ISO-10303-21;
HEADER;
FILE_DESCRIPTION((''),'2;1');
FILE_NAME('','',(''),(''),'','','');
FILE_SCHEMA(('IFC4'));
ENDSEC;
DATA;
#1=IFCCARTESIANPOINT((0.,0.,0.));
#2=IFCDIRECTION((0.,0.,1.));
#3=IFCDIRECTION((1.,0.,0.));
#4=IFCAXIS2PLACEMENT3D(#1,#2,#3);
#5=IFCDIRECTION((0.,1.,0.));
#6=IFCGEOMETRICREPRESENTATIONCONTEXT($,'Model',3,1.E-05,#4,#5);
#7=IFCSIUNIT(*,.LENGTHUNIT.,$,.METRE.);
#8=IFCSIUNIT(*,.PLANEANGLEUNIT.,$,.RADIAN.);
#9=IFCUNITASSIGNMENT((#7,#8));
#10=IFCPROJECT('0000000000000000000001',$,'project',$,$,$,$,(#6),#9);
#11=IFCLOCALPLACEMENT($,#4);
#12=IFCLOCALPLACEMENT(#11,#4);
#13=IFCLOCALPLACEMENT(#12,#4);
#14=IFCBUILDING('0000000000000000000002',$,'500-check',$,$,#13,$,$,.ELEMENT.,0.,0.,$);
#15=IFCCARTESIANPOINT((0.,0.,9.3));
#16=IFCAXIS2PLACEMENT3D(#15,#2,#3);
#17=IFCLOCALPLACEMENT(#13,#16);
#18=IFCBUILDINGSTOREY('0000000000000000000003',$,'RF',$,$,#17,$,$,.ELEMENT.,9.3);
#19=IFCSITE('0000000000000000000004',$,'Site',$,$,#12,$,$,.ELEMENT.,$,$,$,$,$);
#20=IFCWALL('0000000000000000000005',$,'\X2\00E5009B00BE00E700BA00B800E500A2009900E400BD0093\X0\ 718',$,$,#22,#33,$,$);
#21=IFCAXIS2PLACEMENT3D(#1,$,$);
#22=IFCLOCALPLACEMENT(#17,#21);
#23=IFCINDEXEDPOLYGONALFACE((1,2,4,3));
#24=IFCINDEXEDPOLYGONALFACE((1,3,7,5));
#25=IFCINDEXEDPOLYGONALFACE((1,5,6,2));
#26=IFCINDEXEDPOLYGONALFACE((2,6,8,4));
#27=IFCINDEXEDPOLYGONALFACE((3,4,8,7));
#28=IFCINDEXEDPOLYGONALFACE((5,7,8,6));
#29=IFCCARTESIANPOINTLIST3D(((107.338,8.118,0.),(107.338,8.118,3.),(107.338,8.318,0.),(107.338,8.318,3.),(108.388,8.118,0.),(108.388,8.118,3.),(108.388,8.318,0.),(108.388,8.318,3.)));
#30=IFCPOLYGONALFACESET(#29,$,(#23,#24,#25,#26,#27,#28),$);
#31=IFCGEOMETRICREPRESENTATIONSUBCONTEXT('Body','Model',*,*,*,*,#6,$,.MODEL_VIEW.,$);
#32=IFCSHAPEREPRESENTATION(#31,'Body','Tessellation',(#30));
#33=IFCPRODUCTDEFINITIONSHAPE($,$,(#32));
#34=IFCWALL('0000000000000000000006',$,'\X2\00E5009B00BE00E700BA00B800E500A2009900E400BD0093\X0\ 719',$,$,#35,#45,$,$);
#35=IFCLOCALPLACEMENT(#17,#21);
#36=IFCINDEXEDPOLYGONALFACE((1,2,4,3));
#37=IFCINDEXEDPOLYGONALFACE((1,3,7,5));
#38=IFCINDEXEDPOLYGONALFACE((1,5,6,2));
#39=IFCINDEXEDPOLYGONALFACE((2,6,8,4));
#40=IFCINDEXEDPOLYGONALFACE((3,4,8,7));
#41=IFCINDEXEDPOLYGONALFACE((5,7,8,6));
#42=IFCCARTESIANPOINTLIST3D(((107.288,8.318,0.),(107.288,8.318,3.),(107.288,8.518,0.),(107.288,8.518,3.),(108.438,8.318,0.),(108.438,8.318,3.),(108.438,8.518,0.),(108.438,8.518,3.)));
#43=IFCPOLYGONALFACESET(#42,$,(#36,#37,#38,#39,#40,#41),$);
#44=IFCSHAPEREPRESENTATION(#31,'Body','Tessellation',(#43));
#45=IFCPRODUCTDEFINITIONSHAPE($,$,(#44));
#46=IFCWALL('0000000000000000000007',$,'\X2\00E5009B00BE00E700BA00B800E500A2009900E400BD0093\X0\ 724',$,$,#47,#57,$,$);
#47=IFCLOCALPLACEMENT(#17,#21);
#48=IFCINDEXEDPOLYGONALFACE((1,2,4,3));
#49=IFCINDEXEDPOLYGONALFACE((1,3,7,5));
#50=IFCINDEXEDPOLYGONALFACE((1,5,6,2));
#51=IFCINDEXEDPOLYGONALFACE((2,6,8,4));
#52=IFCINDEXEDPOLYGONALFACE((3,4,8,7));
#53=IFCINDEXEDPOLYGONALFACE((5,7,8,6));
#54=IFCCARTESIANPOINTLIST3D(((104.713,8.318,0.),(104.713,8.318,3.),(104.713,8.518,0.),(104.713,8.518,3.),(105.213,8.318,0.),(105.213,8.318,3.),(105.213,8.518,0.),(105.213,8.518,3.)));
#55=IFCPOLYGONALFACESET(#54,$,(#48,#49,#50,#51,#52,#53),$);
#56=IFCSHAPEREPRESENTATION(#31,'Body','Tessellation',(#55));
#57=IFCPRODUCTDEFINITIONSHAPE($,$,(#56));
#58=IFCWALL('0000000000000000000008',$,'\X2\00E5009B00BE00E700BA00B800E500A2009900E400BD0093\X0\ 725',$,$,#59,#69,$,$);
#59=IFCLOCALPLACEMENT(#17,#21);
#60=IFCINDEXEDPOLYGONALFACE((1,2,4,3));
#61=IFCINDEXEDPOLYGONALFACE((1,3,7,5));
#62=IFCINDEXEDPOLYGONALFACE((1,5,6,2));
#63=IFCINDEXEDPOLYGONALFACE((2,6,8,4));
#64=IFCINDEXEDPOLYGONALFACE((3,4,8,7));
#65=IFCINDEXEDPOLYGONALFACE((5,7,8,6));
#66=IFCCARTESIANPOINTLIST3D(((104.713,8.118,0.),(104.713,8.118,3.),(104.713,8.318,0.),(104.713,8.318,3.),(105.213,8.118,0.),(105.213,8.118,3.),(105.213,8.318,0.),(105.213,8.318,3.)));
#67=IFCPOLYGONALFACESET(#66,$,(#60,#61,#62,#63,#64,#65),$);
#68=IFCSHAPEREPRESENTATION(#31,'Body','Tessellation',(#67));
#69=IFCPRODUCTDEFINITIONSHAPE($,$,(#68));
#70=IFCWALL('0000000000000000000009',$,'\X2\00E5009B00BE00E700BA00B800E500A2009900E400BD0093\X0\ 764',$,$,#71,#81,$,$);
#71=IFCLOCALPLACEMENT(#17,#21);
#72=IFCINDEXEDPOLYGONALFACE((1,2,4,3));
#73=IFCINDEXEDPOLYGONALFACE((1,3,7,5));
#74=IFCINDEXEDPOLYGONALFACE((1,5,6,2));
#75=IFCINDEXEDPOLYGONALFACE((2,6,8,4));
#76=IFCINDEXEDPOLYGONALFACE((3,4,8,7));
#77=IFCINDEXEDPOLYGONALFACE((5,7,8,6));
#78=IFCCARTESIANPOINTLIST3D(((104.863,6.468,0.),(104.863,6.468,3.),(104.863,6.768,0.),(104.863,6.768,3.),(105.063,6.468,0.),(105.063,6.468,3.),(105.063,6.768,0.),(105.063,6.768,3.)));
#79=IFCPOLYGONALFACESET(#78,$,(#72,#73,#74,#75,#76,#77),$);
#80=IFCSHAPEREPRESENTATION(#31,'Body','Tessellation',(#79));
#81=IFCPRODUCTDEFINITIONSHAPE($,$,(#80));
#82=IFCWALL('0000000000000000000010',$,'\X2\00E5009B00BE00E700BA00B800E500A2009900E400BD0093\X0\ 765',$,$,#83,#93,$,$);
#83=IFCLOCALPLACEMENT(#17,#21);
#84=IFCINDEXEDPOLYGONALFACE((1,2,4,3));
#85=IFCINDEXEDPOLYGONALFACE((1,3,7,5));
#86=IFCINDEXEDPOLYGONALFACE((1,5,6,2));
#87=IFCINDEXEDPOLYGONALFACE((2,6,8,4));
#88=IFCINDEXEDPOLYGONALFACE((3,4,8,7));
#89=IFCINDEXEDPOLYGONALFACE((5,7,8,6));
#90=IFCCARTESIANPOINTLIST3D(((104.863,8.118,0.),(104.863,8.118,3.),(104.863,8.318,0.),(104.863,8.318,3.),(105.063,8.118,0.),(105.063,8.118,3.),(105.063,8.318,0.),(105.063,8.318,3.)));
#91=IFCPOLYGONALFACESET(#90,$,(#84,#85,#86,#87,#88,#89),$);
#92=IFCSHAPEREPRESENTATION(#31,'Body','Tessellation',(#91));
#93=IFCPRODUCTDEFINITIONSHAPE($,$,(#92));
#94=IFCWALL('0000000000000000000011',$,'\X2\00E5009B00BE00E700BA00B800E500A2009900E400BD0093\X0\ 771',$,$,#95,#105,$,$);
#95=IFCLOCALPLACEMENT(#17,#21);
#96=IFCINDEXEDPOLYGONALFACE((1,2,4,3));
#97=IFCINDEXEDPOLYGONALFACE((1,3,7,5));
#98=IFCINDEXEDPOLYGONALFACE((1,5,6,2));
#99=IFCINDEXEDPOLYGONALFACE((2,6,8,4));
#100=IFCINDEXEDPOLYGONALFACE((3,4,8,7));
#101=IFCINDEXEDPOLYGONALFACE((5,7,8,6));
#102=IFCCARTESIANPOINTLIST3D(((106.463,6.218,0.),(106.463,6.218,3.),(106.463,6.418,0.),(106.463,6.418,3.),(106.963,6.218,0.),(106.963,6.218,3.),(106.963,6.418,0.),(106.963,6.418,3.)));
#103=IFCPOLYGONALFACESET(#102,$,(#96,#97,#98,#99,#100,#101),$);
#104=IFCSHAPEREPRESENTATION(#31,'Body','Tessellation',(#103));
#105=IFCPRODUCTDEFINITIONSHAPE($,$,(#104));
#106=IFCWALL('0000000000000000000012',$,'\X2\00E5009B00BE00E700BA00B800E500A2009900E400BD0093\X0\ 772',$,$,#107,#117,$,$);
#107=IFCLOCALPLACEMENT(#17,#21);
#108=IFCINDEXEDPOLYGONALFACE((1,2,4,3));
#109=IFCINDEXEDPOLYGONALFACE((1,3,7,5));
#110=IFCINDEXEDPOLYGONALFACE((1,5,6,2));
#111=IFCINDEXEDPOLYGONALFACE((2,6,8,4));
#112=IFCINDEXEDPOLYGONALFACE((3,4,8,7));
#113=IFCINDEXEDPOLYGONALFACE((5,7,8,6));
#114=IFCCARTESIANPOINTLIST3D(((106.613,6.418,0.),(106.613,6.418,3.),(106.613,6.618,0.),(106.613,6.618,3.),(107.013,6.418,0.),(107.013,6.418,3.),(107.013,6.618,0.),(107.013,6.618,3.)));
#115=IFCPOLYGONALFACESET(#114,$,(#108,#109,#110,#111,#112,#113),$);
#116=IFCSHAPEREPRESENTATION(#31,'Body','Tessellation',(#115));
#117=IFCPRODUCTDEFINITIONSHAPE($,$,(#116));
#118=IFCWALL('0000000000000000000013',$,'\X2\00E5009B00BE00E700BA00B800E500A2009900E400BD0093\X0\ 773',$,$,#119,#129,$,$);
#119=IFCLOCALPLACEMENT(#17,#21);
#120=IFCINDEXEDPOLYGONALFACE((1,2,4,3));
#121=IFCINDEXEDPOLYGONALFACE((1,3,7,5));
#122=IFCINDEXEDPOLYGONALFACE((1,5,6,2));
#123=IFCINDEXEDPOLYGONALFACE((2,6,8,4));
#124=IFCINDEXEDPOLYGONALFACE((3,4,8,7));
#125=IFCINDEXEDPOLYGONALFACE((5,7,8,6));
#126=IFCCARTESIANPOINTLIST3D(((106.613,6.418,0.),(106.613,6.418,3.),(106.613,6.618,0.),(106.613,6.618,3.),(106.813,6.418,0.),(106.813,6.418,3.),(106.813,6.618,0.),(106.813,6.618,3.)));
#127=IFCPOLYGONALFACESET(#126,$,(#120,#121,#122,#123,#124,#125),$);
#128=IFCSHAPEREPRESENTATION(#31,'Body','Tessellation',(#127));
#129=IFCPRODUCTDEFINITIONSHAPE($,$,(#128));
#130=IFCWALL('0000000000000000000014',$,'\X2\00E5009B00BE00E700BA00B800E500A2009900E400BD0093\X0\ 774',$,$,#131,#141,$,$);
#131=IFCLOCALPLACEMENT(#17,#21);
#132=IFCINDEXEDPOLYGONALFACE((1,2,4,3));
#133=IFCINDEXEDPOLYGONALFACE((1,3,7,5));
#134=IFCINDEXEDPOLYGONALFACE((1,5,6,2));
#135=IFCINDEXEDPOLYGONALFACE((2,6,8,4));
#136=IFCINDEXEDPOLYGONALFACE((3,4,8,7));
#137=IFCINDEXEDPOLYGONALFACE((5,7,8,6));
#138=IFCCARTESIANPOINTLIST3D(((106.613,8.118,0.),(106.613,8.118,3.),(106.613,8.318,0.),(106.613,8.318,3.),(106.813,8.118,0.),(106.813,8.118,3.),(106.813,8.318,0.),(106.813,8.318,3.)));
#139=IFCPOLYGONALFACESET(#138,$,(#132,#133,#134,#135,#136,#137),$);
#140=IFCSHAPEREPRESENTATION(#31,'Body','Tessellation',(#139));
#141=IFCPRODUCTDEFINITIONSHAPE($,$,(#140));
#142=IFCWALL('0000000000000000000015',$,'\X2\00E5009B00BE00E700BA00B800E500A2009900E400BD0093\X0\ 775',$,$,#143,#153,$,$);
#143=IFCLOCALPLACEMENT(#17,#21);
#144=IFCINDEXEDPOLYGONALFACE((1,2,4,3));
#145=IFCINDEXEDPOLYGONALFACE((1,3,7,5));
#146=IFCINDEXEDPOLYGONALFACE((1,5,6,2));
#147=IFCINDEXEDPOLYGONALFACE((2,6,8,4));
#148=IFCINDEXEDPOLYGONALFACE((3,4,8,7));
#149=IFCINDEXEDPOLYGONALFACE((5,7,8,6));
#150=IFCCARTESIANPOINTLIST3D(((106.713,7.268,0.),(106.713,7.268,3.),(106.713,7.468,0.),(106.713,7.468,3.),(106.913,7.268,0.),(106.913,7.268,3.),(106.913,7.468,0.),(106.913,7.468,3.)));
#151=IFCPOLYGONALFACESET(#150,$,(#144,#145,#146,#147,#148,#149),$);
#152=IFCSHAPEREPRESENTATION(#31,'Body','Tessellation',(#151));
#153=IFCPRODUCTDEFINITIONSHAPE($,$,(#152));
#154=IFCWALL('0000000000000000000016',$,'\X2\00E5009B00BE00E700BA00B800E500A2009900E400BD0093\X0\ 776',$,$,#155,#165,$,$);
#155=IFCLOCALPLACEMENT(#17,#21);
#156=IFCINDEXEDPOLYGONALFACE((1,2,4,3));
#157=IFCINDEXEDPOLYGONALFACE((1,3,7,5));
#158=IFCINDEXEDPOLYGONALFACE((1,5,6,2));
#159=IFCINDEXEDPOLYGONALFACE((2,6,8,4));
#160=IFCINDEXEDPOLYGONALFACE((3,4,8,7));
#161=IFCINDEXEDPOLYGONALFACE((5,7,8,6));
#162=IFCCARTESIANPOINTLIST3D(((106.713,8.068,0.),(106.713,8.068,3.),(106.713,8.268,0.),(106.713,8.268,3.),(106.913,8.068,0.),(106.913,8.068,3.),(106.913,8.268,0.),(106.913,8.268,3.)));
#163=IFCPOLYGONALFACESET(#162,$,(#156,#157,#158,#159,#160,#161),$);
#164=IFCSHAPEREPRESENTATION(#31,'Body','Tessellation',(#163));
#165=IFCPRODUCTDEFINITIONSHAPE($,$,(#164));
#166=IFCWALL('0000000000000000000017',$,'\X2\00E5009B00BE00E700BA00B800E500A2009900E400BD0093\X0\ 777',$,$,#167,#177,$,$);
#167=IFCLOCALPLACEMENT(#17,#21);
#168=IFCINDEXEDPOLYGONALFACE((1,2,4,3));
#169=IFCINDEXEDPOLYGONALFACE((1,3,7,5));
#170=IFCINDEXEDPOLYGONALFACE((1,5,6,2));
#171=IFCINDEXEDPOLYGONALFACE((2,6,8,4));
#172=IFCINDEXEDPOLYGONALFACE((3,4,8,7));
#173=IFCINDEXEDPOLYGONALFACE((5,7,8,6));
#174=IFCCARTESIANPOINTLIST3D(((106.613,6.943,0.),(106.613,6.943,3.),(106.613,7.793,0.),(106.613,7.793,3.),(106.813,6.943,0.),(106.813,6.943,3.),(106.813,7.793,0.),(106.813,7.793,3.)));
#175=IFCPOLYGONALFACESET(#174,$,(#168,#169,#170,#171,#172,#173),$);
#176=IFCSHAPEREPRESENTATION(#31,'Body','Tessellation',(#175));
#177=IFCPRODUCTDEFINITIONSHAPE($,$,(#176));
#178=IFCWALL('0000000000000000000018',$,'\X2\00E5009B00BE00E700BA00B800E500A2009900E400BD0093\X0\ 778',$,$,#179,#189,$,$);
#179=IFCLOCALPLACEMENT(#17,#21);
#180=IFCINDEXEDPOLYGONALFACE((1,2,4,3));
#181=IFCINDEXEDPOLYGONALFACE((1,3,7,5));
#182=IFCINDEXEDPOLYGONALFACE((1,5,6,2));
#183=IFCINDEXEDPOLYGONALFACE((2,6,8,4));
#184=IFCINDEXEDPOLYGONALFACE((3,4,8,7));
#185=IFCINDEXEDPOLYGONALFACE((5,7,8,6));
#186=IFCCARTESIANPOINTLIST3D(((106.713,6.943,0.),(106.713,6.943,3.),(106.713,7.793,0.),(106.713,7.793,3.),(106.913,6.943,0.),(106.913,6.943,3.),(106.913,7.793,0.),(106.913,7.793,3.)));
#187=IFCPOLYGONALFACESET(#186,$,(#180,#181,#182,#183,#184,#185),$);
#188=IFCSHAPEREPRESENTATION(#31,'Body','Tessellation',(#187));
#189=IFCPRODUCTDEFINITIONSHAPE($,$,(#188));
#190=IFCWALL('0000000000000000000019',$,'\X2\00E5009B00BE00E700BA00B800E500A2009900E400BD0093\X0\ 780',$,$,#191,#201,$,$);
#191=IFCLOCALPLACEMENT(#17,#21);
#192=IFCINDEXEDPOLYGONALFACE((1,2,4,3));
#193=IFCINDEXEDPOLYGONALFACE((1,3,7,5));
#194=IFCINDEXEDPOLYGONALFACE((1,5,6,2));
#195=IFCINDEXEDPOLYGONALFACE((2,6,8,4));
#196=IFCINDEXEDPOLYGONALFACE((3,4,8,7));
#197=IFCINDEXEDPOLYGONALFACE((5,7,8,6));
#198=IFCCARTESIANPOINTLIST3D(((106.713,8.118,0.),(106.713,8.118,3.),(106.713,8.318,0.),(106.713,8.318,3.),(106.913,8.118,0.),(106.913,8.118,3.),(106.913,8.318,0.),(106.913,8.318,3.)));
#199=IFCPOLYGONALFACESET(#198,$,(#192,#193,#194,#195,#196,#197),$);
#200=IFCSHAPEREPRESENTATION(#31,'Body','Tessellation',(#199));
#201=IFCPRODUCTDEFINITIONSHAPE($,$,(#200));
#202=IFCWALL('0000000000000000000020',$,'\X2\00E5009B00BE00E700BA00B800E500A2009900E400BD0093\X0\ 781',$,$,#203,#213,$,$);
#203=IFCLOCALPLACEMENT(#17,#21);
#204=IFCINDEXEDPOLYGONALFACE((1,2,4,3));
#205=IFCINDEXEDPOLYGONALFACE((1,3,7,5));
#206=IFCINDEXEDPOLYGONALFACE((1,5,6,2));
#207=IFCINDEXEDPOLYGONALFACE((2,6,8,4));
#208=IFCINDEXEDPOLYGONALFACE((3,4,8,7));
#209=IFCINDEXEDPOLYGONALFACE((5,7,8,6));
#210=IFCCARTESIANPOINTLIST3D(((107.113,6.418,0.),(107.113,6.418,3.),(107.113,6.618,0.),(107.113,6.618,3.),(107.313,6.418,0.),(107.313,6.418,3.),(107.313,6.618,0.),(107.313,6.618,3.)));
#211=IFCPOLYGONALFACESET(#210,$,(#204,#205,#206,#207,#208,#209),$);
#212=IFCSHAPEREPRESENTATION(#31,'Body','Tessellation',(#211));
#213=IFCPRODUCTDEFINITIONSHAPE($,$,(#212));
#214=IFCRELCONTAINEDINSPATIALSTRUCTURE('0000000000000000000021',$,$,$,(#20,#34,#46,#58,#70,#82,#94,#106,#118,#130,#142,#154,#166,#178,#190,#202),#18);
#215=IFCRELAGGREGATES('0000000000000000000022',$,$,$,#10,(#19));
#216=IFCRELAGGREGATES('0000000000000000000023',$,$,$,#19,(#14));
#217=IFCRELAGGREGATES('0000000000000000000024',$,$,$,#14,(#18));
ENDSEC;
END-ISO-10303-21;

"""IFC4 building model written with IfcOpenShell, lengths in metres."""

from ifc_helpers import new_model, si_unit, direction, frame, frame_2d, origin_with_axes, place, context, subcontext, project, spatial, rectangle, extrude, element, save


model = new_model("IFC4")

# Units and contexts
model_context = context("Model", 3, precision=1e-05, world=origin_with_axes(), true_north=direction((0.0, 1.0, 0.0)))
body_context = subcontext(model_context, "Body", "Model", "MODEL_VIEW")
ifc_project = project(units=[si_unit("LENGTHUNIT", "METRE"), si_unit("PLANEANGLEUNIT", "RADIAN")], contexts=[model_context])

# Site, building, storey
placement = place(None, origin_with_axes())
site_placement = place(placement, origin_with_axes())
site = spatial("IfcSite", under=ifc_project, at=site_placement, Name="Site", CompositionType="ELEMENT")
building_placement = place(site_placement, origin_with_axes())
building = spatial("IfcBuilding", under=site, at=building_placement, Name="500-check", CompositionType="ELEMENT", ElevationOfRefHeight=0.0, ElevationOfTerrain=0.0)
storey_placement = place(building_placement, frame((0.0, 0.0, 9.3), z_axis=(0.0, 0.0, 1.0), x_axis=(1.0, 0.0, 0.0)))
storey = spatial("IfcBuildingStorey", under=building, at=storey_placement, Name="RF", CompositionType="ELEMENT", Elevation=9.3)

# Walls
wall_1_placement = place(storey_placement, frame((107.863, 8.218, 0.0), z_axis=(0.0, 0.0, 1.0), x_axis=(-1.0, 0.0, 0.0)))
element("IfcWall", 1, at=wall_1_placement, inside=storey, Name="å\u009b¾çº¸å¢\u0099ä½\u0093 718", context=body_context, shape_type="SweptSolid", body=[
    extrude(rectangle(XDim=1.05, YDim=0.2, at=frame_2d((0.0, 0.0), x_axis=(1.0, 0.0, 0.0))), frame((0.0, 0.0, 0.0), z_axis=(0.0, 0.0, 1.0)), (0.0, 0.0, 1.0), 3.0),
])
wall_2_placement = place(storey_placement, frame((107.863, 8.418, 0.0), z_axis=(0.0, 0.0, 1.0), x_axis=(-1.0, 0.0, 0.0)))
element("IfcWall", 2, at=wall_2_placement, inside=storey, Name="å\u009b¾çº¸å¢\u0099ä½\u0093 719", context=body_context, shape_type="SweptSolid", body=[
    extrude(rectangle(XDim=1.15, YDim=0.2, at=frame_2d((0.0, 0.0), x_axis=(1.0, 0.0, 0.0))), frame((0.0, 0.0, 0.0), z_axis=(0.0, 0.0, 1.0)), (0.0, 0.0, 1.0), 3.0),
])
for number, where, z_axis, x_axis, name in (
    (3, (104.963, 8.418, 0.0), (0.0, 0.0, 1.0), (-1.0, 0.0, 0.0), "å\u009b¾çº¸å¢\u0099ä½\u0093 724"),
    (4, (104.963, 8.218, 0.0), (0.0, 0.0, 1.0), (-1.0, 0.0, 0.0), "å\u009b¾çº¸å¢\u0099ä½\u0093 725"),
):
    element("IfcWall", number, at=place(storey_placement, frame(where, z_axis=z_axis, x_axis=x_axis)), inside=storey, Name=name, context=body_context, shape_type="SweptSolid", body=[
        extrude(rectangle(XDim=0.5, YDim=0.2, at=frame_2d((0.0, 0.0), x_axis=(1.0, 0.0, 0.0))), frame((0.0, 0.0, 0.0), z_axis=(0.0, 0.0, 1.0)), (0.0, 0.0, 1.0), 3.0),
    ])
wall_3_placement = place(storey_placement, frame((104.963, 6.618, 0.0), z_axis=(0.0, 0.0, 1.0), x_axis=(0.0, -1.0, 0.0)))
element("IfcWall", 5, at=wall_3_placement, inside=storey, Name="å\u009b¾çº¸å¢\u0099ä½\u0093 764", context=body_context, shape_type="SweptSolid", body=[
    extrude(rectangle(XDim=0.3, YDim=0.2, at=frame_2d((0.0, 0.0), x_axis=(1.0, 0.0, 0.0))), frame((0.0, 0.0, 0.0), z_axis=(0.0, 0.0, 1.0)), (0.0, 0.0, 1.0), 3.0),
])
wall_4_placement = place(storey_placement, frame((104.963, 8.218, 0.0), z_axis=(0.0, 0.0, 1.0), x_axis=(0.0, 1.0, 0.0)))
element("IfcWall", 6, at=wall_4_placement, inside=storey, Name="å\u009b¾çº¸å¢\u0099ä½\u0093 765", context=body_context, shape_type="SweptSolid", body=[
    extrude(rectangle(XDim=0.2, YDim=0.2, at=frame_2d((0.0, 0.0), x_axis=(1.0, 0.0, 0.0))), frame((0.0, 0.0, 0.0), z_axis=(0.0, 0.0, 1.0)), (0.0, 0.0, 1.0), 3.0),
])
wall_5_placement = place(storey_placement, frame((106.713, 6.318, 0.0), z_axis=(0.0, 0.0, 1.0), x_axis=(1.0, 0.0, 0.0)))
element("IfcWall", 7, at=wall_5_placement, inside=storey, Name="å\u009b¾çº¸å¢\u0099ä½\u0093 771", context=body_context, shape_type="SweptSolid", body=[
    extrude(rectangle(XDim=0.5, YDim=0.2, at=frame_2d((0.0, 0.0), x_axis=(1.0, 0.0, 0.0))), frame((0.0, 0.0, 0.0), z_axis=(0.0, 0.0, 1.0)), (0.0, 0.0, 1.0), 3.0),
])
wall_6_placement = place(storey_placement, frame((106.813, 6.518, 0.0), z_axis=(0.0, 0.0, 1.0), x_axis=(1.0, 0.0, 0.0)))
element("IfcWall", 8, at=wall_6_placement, inside=storey, Name="å\u009b¾çº¸å¢\u0099ä½\u0093 772", context=body_context, shape_type="SweptSolid", body=[
    extrude(rectangle(XDim=0.4, YDim=0.2, at=frame_2d((0.0, 0.0), x_axis=(1.0, 0.0, 0.0))), frame((0.0, 0.0, 0.0), z_axis=(0.0, 0.0, 1.0)), (0.0, 0.0, 1.0), 3.0),
])
for number, where, z_axis, x_axis, name in (
    (9, (106.713, 6.518, 0.0), (0.0, 0.0, 1.0), (0.0, -1.0, 0.0), "å\u009b¾çº¸å¢\u0099ä½\u0093 773"),
    (10, (106.713, 8.218, 0.0), (0.0, 0.0, 1.0), (0.0, 1.0, 0.0), "å\u009b¾çº¸å¢\u0099ä½\u0093 774"),
    (11, (106.813, 7.368, 0.0), (0.0, 0.0, 1.0), (-1.0, 0.0, 0.0), "å\u009b¾çº¸å¢\u0099ä½\u0093 775"),
    (12, (106.813, 8.168, 0.0), (0.0, 0.0, 1.0), (-1.0, 0.0, 0.0), "å\u009b¾çº¸å¢\u0099ä½\u0093 776"),
):
    element("IfcWall", number, at=place(storey_placement, frame(where, z_axis=z_axis, x_axis=x_axis)), inside=storey, Name=name, context=body_context, shape_type="SweptSolid", body=[
        extrude(rectangle(XDim=0.2, YDim=0.2, at=frame_2d((0.0, 0.0), x_axis=(1.0, 0.0, 0.0))), frame((0.0, 0.0, 0.0), z_axis=(0.0, 0.0, 1.0)), (0.0, 0.0, 1.0), 3.0),
    ])
for number, where, z_axis, x_axis, name in (
    (13, (106.713, 7.368, 0.0), (0.0, 0.0, 1.0), (0.0, -1.0, 0.0), "å\u009b¾çº¸å¢\u0099ä½\u0093 777"),
    (14, (106.813, 7.368, 0.0), (0.0, 0.0, 1.0), (0.0, -1.0, 0.0), "å\u009b¾çº¸å¢\u0099ä½\u0093 778"),
):
    element("IfcWall", number, at=place(storey_placement, frame(where, z_axis=z_axis, x_axis=x_axis)), inside=storey, Name=name, context=body_context, shape_type="SweptSolid", body=[
        extrude(rectangle(XDim=0.85, YDim=0.2, at=frame_2d((0.0, 0.0), x_axis=(1.0, 0.0, 0.0))), frame((0.0, 0.0, 0.0), z_axis=(0.0, 0.0, 1.0)), (0.0, 0.0, 1.0), 3.0),
    ])
for number, where, z_axis, x_axis, name in (
    (15, (106.813, 8.218, 0.0), (0.0, 0.0, 1.0), (0.0, -1.0, 0.0), "å\u009b¾çº¸å¢\u0099ä½\u0093 780"),
    (16, (107.213, 6.518, 0.0), (0.0, 0.0, 1.0), (0.0, -1.0, 0.0), "å\u009b¾çº¸å¢\u0099ä½\u0093 781"),
):
    element("IfcWall", number, at=place(storey_placement, frame(where, z_axis=z_axis, x_axis=x_axis)), inside=storey, Name=name, context=body_context, shape_type="SweptSolid", body=[
        extrude(rectangle(XDim=0.2, YDim=0.2, at=frame_2d((0.0, 0.0), x_axis=(1.0, 0.0, 0.0))), frame((0.0, 0.0, 0.0), z_axis=(0.0, 0.0, 1.0)), (0.0, 0.0, 1.0), 3.0),
    ])

save(model, "model.ifc")
